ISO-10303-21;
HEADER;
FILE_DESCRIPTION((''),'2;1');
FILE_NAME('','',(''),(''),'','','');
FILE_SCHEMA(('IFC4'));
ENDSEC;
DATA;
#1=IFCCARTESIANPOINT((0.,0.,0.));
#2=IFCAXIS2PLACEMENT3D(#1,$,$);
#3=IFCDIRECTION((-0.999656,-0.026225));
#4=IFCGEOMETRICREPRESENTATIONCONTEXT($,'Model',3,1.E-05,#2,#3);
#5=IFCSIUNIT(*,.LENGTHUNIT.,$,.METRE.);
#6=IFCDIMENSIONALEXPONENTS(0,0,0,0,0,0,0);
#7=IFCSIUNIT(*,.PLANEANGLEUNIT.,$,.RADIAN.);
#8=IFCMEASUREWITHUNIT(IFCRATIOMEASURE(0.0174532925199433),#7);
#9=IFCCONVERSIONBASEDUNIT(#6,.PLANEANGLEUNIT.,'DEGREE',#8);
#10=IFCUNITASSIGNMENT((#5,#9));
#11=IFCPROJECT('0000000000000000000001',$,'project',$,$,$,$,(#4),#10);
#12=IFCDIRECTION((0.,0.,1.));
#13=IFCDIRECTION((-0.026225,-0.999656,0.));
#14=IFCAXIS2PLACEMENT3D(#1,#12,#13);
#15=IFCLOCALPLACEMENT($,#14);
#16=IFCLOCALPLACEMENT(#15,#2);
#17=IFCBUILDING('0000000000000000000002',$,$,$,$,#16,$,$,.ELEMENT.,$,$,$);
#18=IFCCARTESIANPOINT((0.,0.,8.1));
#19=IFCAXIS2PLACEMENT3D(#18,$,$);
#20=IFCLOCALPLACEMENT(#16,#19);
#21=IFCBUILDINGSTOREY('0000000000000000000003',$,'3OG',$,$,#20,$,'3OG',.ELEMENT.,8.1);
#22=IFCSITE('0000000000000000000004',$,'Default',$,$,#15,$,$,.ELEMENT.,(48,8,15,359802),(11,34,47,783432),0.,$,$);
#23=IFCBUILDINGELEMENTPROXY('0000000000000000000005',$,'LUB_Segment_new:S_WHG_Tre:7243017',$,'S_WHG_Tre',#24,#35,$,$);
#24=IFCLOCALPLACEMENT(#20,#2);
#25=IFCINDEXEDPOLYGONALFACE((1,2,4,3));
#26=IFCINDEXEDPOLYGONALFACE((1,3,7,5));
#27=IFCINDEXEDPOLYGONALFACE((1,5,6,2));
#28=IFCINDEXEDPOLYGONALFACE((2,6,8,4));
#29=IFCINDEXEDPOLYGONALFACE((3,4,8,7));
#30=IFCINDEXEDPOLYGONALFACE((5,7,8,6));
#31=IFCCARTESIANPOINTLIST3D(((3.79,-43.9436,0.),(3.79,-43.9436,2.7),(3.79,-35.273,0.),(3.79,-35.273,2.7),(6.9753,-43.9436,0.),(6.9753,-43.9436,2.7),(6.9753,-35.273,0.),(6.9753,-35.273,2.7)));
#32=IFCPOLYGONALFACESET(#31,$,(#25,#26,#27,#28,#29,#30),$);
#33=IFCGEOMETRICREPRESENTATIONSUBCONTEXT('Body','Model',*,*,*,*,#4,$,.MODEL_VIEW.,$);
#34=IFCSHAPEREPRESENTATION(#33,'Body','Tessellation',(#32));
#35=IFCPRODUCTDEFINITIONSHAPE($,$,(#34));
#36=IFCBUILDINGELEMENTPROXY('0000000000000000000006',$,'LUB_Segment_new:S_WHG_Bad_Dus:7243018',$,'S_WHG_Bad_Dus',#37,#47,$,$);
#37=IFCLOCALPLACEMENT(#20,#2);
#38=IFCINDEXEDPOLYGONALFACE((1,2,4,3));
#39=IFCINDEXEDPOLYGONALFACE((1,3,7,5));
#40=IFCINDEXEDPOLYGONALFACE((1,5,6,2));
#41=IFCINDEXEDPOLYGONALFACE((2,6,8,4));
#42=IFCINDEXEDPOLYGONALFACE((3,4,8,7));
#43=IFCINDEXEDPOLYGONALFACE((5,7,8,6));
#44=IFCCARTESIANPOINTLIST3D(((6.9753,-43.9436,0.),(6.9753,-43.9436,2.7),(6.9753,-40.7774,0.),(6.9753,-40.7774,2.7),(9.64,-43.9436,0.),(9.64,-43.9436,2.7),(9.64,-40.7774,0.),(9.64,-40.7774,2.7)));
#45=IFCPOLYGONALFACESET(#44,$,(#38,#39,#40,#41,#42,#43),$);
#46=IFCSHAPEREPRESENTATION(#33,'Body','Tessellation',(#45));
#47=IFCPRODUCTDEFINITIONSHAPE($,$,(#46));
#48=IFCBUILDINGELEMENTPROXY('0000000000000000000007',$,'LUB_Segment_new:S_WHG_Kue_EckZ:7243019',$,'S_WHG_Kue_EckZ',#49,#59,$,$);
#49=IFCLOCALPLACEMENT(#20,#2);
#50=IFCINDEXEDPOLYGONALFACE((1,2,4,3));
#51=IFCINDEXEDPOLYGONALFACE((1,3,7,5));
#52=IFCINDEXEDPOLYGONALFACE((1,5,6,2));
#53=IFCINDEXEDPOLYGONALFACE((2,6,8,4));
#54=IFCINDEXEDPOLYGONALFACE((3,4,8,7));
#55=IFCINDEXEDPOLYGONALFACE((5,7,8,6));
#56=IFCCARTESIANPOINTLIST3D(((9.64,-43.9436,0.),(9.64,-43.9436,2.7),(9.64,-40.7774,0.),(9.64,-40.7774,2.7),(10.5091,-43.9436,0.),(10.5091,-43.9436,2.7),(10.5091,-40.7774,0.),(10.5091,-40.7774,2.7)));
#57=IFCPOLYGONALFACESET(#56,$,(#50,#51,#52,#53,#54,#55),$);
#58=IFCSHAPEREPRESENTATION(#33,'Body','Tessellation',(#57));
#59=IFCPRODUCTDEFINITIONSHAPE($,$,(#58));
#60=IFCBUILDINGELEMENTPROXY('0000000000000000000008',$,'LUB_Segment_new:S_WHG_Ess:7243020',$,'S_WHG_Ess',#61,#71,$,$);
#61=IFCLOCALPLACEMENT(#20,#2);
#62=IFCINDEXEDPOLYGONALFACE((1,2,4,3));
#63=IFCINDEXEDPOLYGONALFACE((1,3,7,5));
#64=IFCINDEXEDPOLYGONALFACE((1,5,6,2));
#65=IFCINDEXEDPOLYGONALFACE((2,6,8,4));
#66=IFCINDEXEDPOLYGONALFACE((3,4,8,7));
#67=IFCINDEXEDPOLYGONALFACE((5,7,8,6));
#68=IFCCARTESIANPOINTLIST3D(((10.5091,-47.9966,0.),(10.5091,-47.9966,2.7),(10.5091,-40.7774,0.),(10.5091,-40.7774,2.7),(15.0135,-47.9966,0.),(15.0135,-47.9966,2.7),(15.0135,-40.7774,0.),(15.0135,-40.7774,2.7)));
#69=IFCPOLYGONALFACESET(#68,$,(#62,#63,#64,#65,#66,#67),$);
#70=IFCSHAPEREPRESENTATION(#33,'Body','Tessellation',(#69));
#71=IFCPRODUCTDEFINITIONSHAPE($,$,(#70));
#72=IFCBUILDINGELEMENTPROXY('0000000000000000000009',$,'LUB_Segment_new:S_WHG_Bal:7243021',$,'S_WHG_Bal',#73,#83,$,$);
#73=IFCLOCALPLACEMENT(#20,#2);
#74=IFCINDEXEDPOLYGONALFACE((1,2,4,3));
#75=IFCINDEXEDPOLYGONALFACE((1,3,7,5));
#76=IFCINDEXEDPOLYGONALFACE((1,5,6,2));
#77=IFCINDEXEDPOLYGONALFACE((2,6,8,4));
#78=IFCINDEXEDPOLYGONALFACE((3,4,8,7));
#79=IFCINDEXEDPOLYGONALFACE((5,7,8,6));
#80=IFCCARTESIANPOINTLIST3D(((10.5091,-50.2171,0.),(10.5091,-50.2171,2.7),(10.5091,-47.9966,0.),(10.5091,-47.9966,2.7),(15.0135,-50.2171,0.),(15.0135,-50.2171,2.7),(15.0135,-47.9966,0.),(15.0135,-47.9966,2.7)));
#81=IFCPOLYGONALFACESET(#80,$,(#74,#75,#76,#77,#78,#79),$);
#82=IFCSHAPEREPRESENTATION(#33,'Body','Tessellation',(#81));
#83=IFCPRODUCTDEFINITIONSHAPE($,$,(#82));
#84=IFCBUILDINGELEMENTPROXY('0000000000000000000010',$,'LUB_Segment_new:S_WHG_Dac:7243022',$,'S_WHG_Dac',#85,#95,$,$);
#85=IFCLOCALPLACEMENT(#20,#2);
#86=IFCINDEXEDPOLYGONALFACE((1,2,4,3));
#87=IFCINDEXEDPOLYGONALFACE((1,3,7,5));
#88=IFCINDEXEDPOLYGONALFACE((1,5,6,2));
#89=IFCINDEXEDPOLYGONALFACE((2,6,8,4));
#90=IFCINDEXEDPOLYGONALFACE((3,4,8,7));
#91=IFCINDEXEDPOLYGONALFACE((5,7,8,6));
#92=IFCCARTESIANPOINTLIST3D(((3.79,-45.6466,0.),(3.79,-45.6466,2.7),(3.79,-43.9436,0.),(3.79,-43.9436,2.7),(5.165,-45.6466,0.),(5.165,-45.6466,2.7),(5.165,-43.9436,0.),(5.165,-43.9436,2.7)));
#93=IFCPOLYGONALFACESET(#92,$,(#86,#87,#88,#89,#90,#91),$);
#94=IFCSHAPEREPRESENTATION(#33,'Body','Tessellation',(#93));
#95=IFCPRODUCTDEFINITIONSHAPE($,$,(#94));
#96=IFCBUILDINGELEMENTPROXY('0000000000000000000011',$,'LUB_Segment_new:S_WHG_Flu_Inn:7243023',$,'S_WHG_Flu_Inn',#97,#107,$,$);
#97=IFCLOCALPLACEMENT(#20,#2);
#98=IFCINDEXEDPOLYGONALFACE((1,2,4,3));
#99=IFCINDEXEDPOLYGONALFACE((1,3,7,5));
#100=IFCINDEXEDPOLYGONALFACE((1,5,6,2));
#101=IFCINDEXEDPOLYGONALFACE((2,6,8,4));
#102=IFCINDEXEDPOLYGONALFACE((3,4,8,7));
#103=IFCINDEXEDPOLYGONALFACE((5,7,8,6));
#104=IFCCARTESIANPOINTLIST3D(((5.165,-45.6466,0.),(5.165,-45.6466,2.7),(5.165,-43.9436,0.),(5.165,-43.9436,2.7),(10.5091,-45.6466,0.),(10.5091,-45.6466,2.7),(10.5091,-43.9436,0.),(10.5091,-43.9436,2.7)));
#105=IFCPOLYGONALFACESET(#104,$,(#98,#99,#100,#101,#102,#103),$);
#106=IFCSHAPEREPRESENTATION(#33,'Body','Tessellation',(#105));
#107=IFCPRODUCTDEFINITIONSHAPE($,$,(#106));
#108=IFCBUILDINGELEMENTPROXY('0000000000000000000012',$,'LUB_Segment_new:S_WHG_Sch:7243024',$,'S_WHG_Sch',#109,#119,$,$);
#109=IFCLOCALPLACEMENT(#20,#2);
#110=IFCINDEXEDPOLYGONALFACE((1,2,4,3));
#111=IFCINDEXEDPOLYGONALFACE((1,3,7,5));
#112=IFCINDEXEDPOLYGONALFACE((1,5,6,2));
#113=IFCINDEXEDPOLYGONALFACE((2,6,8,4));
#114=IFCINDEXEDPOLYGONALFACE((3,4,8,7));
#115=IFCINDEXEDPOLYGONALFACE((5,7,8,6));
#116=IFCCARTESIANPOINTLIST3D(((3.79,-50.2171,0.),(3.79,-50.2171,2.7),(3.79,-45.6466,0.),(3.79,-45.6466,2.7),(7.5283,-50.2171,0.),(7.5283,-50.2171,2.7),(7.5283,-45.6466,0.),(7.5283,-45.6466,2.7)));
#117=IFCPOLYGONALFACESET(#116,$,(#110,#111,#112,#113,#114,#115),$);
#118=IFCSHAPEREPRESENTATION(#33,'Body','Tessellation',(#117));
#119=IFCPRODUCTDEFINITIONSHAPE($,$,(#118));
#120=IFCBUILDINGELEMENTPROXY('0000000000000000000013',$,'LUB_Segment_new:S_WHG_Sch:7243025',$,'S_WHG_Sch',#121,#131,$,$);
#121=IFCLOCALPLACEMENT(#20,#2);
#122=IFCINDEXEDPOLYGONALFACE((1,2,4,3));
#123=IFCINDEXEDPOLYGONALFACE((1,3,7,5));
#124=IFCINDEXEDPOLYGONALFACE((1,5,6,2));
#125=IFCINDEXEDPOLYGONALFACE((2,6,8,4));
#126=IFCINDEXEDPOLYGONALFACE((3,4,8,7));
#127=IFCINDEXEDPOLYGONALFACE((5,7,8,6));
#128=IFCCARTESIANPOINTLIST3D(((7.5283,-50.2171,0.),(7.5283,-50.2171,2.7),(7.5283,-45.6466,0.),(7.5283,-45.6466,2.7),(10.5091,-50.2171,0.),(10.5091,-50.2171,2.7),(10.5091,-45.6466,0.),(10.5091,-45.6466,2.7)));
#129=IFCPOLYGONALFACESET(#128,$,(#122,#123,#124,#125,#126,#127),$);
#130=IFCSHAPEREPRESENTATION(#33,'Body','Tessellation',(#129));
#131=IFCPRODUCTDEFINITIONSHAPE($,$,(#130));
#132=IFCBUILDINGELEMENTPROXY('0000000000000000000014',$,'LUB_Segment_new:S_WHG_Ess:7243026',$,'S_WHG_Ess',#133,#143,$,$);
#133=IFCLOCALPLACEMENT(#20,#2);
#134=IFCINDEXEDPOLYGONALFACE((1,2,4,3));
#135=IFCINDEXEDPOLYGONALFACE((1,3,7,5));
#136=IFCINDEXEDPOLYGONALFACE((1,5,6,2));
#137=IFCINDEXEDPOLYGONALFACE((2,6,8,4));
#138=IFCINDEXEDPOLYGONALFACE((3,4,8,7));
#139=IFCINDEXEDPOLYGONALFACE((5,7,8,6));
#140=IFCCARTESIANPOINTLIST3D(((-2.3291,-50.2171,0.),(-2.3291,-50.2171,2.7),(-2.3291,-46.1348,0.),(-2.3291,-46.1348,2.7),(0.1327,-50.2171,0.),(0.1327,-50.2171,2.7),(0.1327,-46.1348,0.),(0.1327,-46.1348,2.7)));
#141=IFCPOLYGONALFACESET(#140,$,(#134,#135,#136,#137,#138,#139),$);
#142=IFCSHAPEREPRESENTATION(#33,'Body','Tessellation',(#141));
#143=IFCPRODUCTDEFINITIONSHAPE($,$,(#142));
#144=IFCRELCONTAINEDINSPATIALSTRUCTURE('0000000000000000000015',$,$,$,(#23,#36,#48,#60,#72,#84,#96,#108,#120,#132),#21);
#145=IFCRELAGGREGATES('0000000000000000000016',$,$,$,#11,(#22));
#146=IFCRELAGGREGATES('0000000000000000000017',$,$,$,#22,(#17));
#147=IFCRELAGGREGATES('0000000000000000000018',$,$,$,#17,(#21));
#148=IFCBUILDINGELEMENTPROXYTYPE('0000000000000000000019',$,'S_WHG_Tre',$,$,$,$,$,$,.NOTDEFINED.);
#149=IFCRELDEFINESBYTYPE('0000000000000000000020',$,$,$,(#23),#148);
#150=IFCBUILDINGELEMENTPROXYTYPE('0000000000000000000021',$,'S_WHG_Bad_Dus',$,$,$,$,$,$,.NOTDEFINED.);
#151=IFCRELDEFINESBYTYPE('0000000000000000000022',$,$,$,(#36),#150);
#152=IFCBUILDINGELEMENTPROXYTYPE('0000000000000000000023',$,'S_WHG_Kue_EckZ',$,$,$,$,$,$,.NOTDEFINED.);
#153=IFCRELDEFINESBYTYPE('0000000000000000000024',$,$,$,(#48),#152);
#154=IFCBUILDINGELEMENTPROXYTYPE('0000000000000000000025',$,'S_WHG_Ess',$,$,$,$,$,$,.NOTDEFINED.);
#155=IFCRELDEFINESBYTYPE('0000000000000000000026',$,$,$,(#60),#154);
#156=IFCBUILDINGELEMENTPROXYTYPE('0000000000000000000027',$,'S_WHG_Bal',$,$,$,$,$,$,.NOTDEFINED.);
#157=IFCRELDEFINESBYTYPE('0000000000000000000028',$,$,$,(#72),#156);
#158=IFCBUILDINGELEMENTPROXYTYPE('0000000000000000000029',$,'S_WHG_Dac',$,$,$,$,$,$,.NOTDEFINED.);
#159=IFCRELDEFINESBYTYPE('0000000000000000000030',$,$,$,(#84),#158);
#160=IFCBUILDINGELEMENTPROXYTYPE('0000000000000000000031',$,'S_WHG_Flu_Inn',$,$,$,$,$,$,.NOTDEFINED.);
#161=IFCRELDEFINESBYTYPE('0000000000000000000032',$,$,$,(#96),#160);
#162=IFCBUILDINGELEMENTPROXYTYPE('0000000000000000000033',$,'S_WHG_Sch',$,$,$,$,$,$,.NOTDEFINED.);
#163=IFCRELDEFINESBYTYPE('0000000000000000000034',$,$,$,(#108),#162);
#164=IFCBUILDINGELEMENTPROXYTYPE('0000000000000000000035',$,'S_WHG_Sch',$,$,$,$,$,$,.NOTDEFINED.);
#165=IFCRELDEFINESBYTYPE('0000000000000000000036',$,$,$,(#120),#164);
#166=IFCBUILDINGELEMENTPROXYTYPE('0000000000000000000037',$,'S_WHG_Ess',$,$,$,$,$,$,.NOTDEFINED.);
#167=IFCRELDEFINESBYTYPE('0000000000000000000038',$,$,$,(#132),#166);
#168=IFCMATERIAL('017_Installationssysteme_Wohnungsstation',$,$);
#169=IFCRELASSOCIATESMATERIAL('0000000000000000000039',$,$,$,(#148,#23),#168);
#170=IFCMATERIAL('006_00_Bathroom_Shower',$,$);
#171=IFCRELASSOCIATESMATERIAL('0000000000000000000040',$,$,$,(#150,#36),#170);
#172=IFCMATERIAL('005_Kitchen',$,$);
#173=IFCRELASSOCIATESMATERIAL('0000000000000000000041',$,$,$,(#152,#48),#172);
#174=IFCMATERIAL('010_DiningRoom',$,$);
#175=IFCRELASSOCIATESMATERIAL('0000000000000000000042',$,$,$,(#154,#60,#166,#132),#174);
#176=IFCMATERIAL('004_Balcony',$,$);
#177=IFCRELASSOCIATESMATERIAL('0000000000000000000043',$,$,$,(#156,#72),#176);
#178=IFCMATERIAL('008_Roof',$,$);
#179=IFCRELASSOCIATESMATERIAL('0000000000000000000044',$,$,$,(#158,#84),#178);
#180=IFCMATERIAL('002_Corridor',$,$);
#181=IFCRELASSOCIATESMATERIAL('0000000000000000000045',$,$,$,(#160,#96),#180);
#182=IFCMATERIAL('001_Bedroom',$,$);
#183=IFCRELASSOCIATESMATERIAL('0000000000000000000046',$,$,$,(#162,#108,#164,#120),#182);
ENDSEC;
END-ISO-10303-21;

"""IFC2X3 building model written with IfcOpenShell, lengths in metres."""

from ifc_helpers import new_model, entity, si_unit, converted_unit, direction, frame, frame_2d, origin, origin_2d_with_axis, place, context, subcontext, project, spatial, rectangle, extrude, source, transform, mapped, material, type_object, type_shapes, element, save


model = new_model("IFC2X3")

# Units and contexts
model_context = context("Model", 3, precision=1e-05, world=origin(), true_north=direction((-0.999656, -0.026225)))
body_context = subcontext(model_context, "Body", "Model", "MODEL_VIEW")
ifc_project = project(units=[si_unit("LENGTHUNIT", "METRE"), converted_unit("PLANEANGLEUNIT", "DEGREE", entity("IfcRatioMeasure", 0.0174532925199433), si_unit("PLANEANGLEUNIT", "RADIAN"), dimensions=[0, 0, 0, 0, 0, 0, 0])], contexts=[model_context])

# Site, building, storey
site_placement = place(None, frame((0.0, 0.0, 0.0), z_axis=(0.0, 0.0, 1.0), x_axis=(-0.026225, -0.999656, 0.0)))
site = spatial("IfcSite", under=ifc_project, at=site_placement, Name="Default", CompositionType="ELEMENT", RefLatitude=(48, 8, 15, 359802), RefLongitude=(11, 34, 47, 783432), RefElevation=0.0)
building_placement = place(site_placement, origin())
building = spatial("IfcBuilding", under=site, at=building_placement, CompositionType="ELEMENT")
storey_placement = place(building_placement, frame((0.0, 0.0, 8.1)))
storey = spatial("IfcBuildingStorey", under=building, at=storey_placement, Name="3OG", LongName="3OG", CompositionType="ELEMENT", Elevation=8.1)

# Building element proxies
ifc_material_1 = material(Name="001_Bedroom")
ifc_material_2 = material(Name="010_DiningRoom")
ifc_material_3 = material(Name="004_Balcony")
ifc_material_4 = material(Name="005_Kitchen")
ifc_material_5 = material(Name="002_Corridor")
ifc_material_6 = material(Name="008_Roof")
ifc_material_7 = material(Name="006_00_Bathroom_Shower")
ifc_material_8 = material(Name="017_Installationssysteme_Wohnungsstation")
building_element_proxy_type_1 = type_object("IfcBuildingElementProxyType", Name="S_WHG_Tre", PredefinedType="NOTDEFINED", material=ifc_material_8)
shared_shape_1 = source(origin(), body_context, "Body", "SweptSolid", [
    extrude(rectangle(XDim=3.1853, YDim=8.6706, at=frame_2d((0.0, 0.0), x_axis=(1.0, 0.0))), frame((0.0, 0.0, 0.0), z_axis=(0.0, 0.0, 1.0), x_axis=(-1.0, 0.0, 0.0)), (0.0, 0.0, 1.0), 2.7),
])
type_shapes(building_element_proxy_type_1, [shared_shape_1])
proxy_1_placement = place(storey_placement, frame((5.3827, -39.6083, 0.0)))
element("IfcBuildingElementProxy", 1, at=proxy_1_placement, inside=storey, type_object=building_element_proxy_type_1, material=ifc_material_8, Name="LUB_Segment_new:S_WHG_Tre:7243017", ObjectType="S_WHG_Tre", context=body_context, shape_type="MappedRepresentation", body=[
    mapped(shared_shape_1, transform((0.0, 0.0, 0.0), scale=1.0)),
])
building_element_proxy_type_2 = type_object("IfcBuildingElementProxyType", Name="S_WHG_Bad_Dus", PredefinedType="NOTDEFINED", material=ifc_material_7)
shared_shape_2 = source(origin(), body_context, "Body", "SweptSolid", [
    extrude(rectangle(XDim=3.1662, YDim=2.6647, at=origin_2d_with_axis()), frame((0.0, 0.0, 0.0), z_axis=(0.0, 0.0, 1.0), x_axis=(0.0, 1.0, 0.0)), (0.0, 0.0, 1.0), 2.7),
])
type_shapes(building_element_proxy_type_2, [shared_shape_2])
proxy_2_placement = place(storey_placement, frame((8.3077, -42.3605, 0.0)))
element("IfcBuildingElementProxy", 2, at=proxy_2_placement, inside=storey, type_object=building_element_proxy_type_2, material=ifc_material_7, Name="LUB_Segment_new:S_WHG_Bad_Dus:7243018", ObjectType="S_WHG_Bad_Dus", context=body_context, shape_type="MappedRepresentation", body=[
    mapped(shared_shape_2, transform((0.0, 0.0, 0.0), scale=1.0)),
])
building_element_proxy_type_3 = type_object("IfcBuildingElementProxyType", Name="S_WHG_Kue_EckZ", PredefinedType="NOTDEFINED", material=ifc_material_4)
shared_shape_3 = source(origin(), body_context, "Body", "SweptSolid", [
    extrude(rectangle(XDim=3.1662, YDim=0.8691, at=origin_2d_with_axis()), frame((0.0, 0.0, 0.0), z_axis=(0.0, 0.0, 1.0), x_axis=(0.0, 1.0, 0.0)), (0.0, 0.0, 1.0), 2.7),
])
type_shapes(building_element_proxy_type_3, [shared_shape_3])
proxy_3_placement = place(storey_placement, frame((10.0746, -42.3605, 0.0)))
element("IfcBuildingElementProxy", 3, at=proxy_3_placement, inside=storey, type_object=building_element_proxy_type_3, material=ifc_material_4, Name="LUB_Segment_new:S_WHG_Kue_EckZ:7243019", ObjectType="S_WHG_Kue_EckZ", context=body_context, shape_type="MappedRepresentation", body=[
    mapped(shared_shape_3, transform((0.0, 0.0, 0.0), scale=1.0)),
])
building_element_proxy_type_4 = type_object("IfcBuildingElementProxyType", Name="S_WHG_Ess", PredefinedType="NOTDEFINED", material=ifc_material_2)
shared_shape_4 = source(origin(), body_context, "Body", "SweptSolid", [
    extrude(rectangle(XDim=4.5044, YDim=7.2191, at=origin_2d_with_axis()), frame((0.0, 0.0, 0.0), z_axis=(0.0, 0.0, 1.0), x_axis=(-1.0, 0.0, 0.0)), (0.0, 0.0, 1.0), 2.7),
])
type_shapes(building_element_proxy_type_4, [shared_shape_4])
proxy_4_placement = place(storey_placement, frame((12.7613, -44.387, 0.0)))
element("IfcBuildingElementProxy", 4, at=proxy_4_placement, inside=storey, type_object=building_element_proxy_type_4, material=ifc_material_2, Name="LUB_Segment_new:S_WHG_Ess:7243020", ObjectType="S_WHG_Ess", context=body_context, shape_type="MappedRepresentation", body=[
    mapped(shared_shape_4, transform((0.0, 0.0, 0.0), scale=1.0)),
])
building_element_proxy_type_5 = type_object("IfcBuildingElementProxyType", Name="S_WHG_Bal", PredefinedType="NOTDEFINED", material=ifc_material_3)
shared_shape_5 = source(origin(), body_context, "Body", "SweptSolid", [
    extrude(rectangle(XDim=2.2206, YDim=4.5044, at=origin_2d_with_axis()), frame((0.0, 0.0, 0.0), z_axis=(0.0, 0.0, 1.0), x_axis=(0.0, 1.0, 0.0)), (0.0, 0.0, 1.0), 2.7),
])
type_shapes(building_element_proxy_type_5, [shared_shape_5])
proxy_5_placement = place(storey_placement, frame((12.7613, -49.1068, 0.0)))
element("IfcBuildingElementProxy", 5, at=proxy_5_placement, inside=storey, type_object=building_element_proxy_type_5, material=ifc_material_3, Name="LUB_Segment_new:S_WHG_Bal:7243021", ObjectType="S_WHG_Bal", context=body_context, shape_type="MappedRepresentation", body=[
    mapped(shared_shape_5, transform((0.0, 0.0, 0.0), scale=1.0)),
])
building_element_proxy_type_6 = type_object("IfcBuildingElementProxyType", Name="S_WHG_Dac", PredefinedType="NOTDEFINED", material=ifc_material_6)
shared_shape_6 = source(origin(), body_context, "Body", "SweptSolid", [
    extrude(rectangle(XDim=1.7029, YDim=1.375, at=origin_2d_with_axis()), frame((0.0, 0.0, 0.0), z_axis=(0.0, 0.0, 1.0), x_axis=(0.0, 1.0, 0.0)), (0.0, 0.0, 1.0), 2.7),
])
type_shapes(building_element_proxy_type_6, [shared_shape_6])
proxy_6_placement = place(storey_placement, frame((4.4775, -44.7951, 0.0)))
element("IfcBuildingElementProxy", 6, at=proxy_6_placement, inside=storey, type_object=building_element_proxy_type_6, material=ifc_material_6, Name="LUB_Segment_new:S_WHG_Dac:7243022", ObjectType="S_WHG_Dac", context=body_context, shape_type="MappedRepresentation", body=[
    mapped(shared_shape_6, transform((0.0, 0.0, 0.0), scale=1.0)),
])
building_element_proxy_type_7 = type_object("IfcBuildingElementProxyType", Name="S_WHG_Flu_Inn", PredefinedType="NOTDEFINED", material=ifc_material_5)
shared_shape_7 = source(origin(), body_context, "Body", "SweptSolid", [
    extrude(rectangle(XDim=1.7029, YDim=5.3441, at=origin_2d_with_axis()), frame((0.0, 0.0, 0.0), z_axis=(0.0, 0.0, 1.0), x_axis=(0.0, 1.0, 0.0)), (0.0, 0.0, 1.0), 2.7),
])
type_shapes(building_element_proxy_type_7, [shared_shape_7])
proxy_7_placement = place(storey_placement, frame((7.8371, -44.7951, 0.0)))
element("IfcBuildingElementProxy", 7, at=proxy_7_placement, inside=storey, type_object=building_element_proxy_type_7, material=ifc_material_5, Name="LUB_Segment_new:S_WHG_Flu_Inn:7243023", ObjectType="S_WHG_Flu_Inn", context=body_context, shape_type="MappedRepresentation", body=[
    mapped(shared_shape_7, transform((0.0, 0.0, 0.0), scale=1.0)),
])
building_element_proxy_type_8 = type_object("IfcBuildingElementProxyType", Name="S_WHG_Sch", PredefinedType="NOTDEFINED", material=ifc_material_1)
shared_shape_8 = source(origin(), body_context, "Body", "SweptSolid", [
    extrude(rectangle(XDim=3.7382, YDim=4.5706, at=origin_2d_with_axis()), frame((0.0, 0.0, 0.0), z_axis=(0.0, 0.0, 1.0), x_axis=(-1.0, 0.0, 0.0)), (0.0, 0.0, 1.0), 2.7),
])
type_shapes(building_element_proxy_type_8, [shared_shape_8])
proxy_8_placement = place(storey_placement, frame((5.6591, -47.9318, 0.0)))
element("IfcBuildingElementProxy", 8, at=proxy_8_placement, inside=storey, type_object=building_element_proxy_type_8, material=ifc_material_1, Name="LUB_Segment_new:S_WHG_Sch:7243024", ObjectType="S_WHG_Sch", context=body_context, shape_type="MappedRepresentation", body=[
    mapped(shared_shape_8, transform((0.0, 0.0, 0.0), scale=1.0)),
])
building_element_proxy_type_9 = type_object("IfcBuildingElementProxyType", Name="S_WHG_Sch", PredefinedType="NOTDEFINED", material=ifc_material_1)
shared_shape_9 = source(origin(), body_context, "Body", "SweptSolid", [
    extrude(rectangle(XDim=2.9809, YDim=4.5706, at=origin_2d_with_axis()), frame((0.0, 0.0, 0.0), z_axis=(0.0, 0.0, 1.0), x_axis=(-1.0, 0.0, 0.0)), (0.0, 0.0, 1.0), 2.7),
])
type_shapes(building_element_proxy_type_9, [shared_shape_9])
proxy_9_placement = place(storey_placement, frame((9.0187, -47.9318, 0.0)))
element("IfcBuildingElementProxy", 9, at=proxy_9_placement, inside=storey, type_object=building_element_proxy_type_9, material=ifc_material_1, Name="LUB_Segment_new:S_WHG_Sch:7243025", ObjectType="S_WHG_Sch", context=body_context, shape_type="MappedRepresentation", body=[
    mapped(shared_shape_9, transform((0.0, 0.0, 0.0), scale=1.0)),
])
building_element_proxy_type_10 = type_object("IfcBuildingElementProxyType", Name="S_WHG_Ess", PredefinedType="NOTDEFINED", material=ifc_material_2)
shared_shape_10 = source(origin(), body_context, "Body", "SweptSolid", [
    extrude(rectangle(XDim=4.0824, YDim=2.4618, at=origin_2d_with_axis()), frame((0.0, 0.0, 0.0), z_axis=(0.0, 0.0, 1.0), x_axis=(0.0, 1.0, 0.0)), (0.0, 0.0, 1.0), 2.7),
])
type_shapes(building_element_proxy_type_10, [shared_shape_10])
proxy_10_placement = place(storey_placement, frame((-1.0982, -48.176, 0.0)))
element("IfcBuildingElementProxy", 10, at=proxy_10_placement, inside=storey, type_object=building_element_proxy_type_10, material=ifc_material_2, Name="LUB_Segment_new:S_WHG_Ess:7243026", ObjectType="S_WHG_Ess", context=body_context, shape_type="MappedRepresentation", body=[
    mapped(shared_shape_10, transform((0.0, 0.0, 0.0), scale=1.0)),
])

save(model, "model.ifc")
